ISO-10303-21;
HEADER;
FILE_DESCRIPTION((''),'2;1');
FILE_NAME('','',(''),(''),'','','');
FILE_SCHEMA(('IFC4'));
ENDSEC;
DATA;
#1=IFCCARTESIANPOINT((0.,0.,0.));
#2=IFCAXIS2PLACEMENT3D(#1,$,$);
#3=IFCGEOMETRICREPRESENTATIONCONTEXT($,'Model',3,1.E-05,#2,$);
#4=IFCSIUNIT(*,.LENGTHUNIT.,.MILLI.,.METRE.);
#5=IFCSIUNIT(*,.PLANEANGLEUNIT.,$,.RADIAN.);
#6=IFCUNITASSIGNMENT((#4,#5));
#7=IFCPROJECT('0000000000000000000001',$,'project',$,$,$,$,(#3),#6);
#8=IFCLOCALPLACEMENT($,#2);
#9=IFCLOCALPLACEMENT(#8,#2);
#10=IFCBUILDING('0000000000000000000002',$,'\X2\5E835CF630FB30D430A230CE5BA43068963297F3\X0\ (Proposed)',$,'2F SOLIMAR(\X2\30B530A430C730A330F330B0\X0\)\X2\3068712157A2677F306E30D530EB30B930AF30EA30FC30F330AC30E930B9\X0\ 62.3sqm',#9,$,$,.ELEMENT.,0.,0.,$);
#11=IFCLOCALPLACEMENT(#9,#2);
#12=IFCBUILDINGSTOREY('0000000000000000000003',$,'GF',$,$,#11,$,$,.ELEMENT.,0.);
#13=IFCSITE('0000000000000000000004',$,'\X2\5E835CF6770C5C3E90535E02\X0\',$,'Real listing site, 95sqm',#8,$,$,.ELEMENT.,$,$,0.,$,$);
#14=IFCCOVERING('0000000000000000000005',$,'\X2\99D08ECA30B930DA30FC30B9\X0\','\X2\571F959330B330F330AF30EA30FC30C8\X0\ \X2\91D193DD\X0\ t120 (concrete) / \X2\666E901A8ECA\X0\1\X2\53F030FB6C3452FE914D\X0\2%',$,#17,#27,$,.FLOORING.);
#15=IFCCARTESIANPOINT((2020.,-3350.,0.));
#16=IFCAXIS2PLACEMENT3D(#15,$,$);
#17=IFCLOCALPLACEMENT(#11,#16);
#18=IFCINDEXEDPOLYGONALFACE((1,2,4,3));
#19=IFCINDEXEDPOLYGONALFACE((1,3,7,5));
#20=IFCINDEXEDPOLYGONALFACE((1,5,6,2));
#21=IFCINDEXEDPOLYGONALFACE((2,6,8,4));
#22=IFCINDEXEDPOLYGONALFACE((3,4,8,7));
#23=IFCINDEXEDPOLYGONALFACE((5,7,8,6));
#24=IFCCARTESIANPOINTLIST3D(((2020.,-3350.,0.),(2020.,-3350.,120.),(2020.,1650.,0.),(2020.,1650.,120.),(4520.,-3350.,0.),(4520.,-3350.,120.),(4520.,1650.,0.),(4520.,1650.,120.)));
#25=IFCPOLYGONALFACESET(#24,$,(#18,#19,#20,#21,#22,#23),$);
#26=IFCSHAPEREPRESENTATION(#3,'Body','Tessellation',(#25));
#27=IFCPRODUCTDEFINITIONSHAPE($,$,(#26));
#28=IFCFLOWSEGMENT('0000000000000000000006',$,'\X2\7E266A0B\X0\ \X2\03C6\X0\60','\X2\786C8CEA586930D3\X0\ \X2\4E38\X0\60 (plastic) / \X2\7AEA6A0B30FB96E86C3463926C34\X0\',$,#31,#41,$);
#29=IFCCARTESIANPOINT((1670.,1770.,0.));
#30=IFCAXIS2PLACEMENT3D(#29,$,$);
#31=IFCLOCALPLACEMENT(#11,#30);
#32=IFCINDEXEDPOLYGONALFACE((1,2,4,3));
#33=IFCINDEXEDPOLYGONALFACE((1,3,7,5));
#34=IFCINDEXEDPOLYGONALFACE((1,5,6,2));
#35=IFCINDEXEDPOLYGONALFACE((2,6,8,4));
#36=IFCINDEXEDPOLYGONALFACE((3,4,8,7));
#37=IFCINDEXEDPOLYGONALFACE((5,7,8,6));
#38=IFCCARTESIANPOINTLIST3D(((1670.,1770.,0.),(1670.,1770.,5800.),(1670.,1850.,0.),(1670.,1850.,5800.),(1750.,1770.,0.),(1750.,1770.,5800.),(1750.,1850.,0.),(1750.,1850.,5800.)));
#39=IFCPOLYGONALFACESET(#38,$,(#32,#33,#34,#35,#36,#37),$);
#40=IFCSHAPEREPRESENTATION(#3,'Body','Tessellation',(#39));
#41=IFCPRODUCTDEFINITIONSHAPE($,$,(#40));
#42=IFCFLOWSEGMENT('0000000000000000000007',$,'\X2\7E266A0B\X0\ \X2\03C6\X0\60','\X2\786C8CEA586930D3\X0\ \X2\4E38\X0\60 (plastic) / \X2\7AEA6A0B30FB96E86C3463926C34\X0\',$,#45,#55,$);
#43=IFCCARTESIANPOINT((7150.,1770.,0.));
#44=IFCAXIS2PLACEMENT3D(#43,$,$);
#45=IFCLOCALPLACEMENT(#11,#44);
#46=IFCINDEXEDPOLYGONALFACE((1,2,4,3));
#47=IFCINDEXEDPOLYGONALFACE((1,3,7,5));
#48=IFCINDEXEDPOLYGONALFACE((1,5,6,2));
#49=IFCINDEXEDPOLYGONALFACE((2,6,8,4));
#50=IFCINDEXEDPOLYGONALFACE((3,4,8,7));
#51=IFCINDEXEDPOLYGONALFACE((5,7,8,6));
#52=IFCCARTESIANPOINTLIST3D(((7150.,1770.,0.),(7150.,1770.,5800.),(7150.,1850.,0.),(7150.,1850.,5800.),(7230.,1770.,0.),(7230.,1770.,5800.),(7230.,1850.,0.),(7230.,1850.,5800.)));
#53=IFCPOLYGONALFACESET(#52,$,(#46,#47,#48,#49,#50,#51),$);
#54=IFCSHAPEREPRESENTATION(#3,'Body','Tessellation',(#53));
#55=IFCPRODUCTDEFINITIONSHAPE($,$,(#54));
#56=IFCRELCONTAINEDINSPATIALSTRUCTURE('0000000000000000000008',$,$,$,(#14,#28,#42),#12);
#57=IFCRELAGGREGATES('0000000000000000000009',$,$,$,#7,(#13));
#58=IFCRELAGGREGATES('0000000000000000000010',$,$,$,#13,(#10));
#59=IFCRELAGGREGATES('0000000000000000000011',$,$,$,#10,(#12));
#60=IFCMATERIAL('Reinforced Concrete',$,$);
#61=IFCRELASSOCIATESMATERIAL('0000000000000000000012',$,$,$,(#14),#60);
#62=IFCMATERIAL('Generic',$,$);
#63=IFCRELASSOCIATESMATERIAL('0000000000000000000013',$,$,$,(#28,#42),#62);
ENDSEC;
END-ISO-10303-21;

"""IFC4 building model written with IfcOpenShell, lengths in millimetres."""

from ifc_helpers import new_model, si_unit, frame, frame_2d, origin, place, context, project, spatial, rectangle, extrude, material, element, save


model = new_model("IFC4")

# Units and contexts
model_context = context("Model", 3, precision=1e-05, world=origin())
ifc_project = project(units=[si_unit("LENGTHUNIT", "METRE", prefix="MILLI"), si_unit("PLANEANGLEUNIT", "RADIAN")], contexts=[model_context])

# Site, building, storey
site_placement = place(None, origin())
site = spatial("IfcSite", under=ifc_project, at=site_placement, Name="広島県尾道市", ObjectType="Real listing site, 95sqm", CompositionType="ELEMENT", RefElevation=0.0)
building_placement = place(site_placement, origin())
building = spatial("IfcBuilding", under=site, at=building_placement, Name="広島・ピアノ室と防音 (Proposed)", ObjectType="2F SOLIMAR(サイディング)と無垢板のフルスクリーンガラス 62.3sqm", CompositionType="ELEMENT", ElevationOfRefHeight=0.0, ElevationOfTerrain=0.0)
storey_placement = place(building_placement, origin())
storey = spatial("IfcBuildingStorey", under=building, at=storey_placement, Name="GF", CompositionType="ELEMENT", Elevation=0.0)

# Shared definitions
ifc_material_1 = material(Name="Reinforced Concrete")

# Covering
covering_1_placement = place(storey_placement, frame((2020.0, -3350.0, 0.0)))
element("IfcCovering", 1, at=covering_1_placement, inside=storey, material=ifc_material_1, Name="駐車スペース", Description="土間コンクリート 金鏝 t120 (concrete) / 普通車1台・水勾配2%", PredefinedType="FLOORING", context=model_context, shape_type="SweptSolid", body=[
    extrude(rectangle(XDim=2500.0, YDim=5000.0, at=frame_2d((1250.0, 2500.0))), frame((2020.0, -3350.0, 0.0)), (0.0, 0.0, 1.0), 120.0),
])

# Flow segments
ifc_material_2 = material(Name="Generic")
flow_segment_1_placement = place(storey_placement, frame((1670.0, 1770.0, 0.0)))
element("IfcFlowSegment", 2, at=flow_segment_1_placement, inside=storey, material=ifc_material_2, Name="縦樋 φ60", Description="硬質塩ビ 丸60 (plastic) / 竪樋・雨水排水", context=model_context, shape_type="SweptSolid", body=[
    extrude(rectangle(XDim=80.0, YDim=80.0, at=frame_2d((40.0, 40.0))), frame((1670.0, 1770.0, 0.0)), (0.0, 0.0, 1.0), 5800.0),
])
flow_segment_2_placement = place(storey_placement, frame((7150.0, 1770.0, 0.0)))
element("IfcFlowSegment", 3, at=flow_segment_2_placement, inside=storey, material=ifc_material_2, Name="縦樋 φ60", Description="硬質塩ビ 丸60 (plastic) / 竪樋・雨水排水", context=model_context, shape_type="SweptSolid", body=[
    extrude(rectangle(XDim=80.0, YDim=80.0, at=frame_2d((40.0, 40.0))), frame((7150.0, 1770.0, 0.0)), (0.0, 0.0, 1.0), 5800.0),
])

save(model, "model.ifc")
